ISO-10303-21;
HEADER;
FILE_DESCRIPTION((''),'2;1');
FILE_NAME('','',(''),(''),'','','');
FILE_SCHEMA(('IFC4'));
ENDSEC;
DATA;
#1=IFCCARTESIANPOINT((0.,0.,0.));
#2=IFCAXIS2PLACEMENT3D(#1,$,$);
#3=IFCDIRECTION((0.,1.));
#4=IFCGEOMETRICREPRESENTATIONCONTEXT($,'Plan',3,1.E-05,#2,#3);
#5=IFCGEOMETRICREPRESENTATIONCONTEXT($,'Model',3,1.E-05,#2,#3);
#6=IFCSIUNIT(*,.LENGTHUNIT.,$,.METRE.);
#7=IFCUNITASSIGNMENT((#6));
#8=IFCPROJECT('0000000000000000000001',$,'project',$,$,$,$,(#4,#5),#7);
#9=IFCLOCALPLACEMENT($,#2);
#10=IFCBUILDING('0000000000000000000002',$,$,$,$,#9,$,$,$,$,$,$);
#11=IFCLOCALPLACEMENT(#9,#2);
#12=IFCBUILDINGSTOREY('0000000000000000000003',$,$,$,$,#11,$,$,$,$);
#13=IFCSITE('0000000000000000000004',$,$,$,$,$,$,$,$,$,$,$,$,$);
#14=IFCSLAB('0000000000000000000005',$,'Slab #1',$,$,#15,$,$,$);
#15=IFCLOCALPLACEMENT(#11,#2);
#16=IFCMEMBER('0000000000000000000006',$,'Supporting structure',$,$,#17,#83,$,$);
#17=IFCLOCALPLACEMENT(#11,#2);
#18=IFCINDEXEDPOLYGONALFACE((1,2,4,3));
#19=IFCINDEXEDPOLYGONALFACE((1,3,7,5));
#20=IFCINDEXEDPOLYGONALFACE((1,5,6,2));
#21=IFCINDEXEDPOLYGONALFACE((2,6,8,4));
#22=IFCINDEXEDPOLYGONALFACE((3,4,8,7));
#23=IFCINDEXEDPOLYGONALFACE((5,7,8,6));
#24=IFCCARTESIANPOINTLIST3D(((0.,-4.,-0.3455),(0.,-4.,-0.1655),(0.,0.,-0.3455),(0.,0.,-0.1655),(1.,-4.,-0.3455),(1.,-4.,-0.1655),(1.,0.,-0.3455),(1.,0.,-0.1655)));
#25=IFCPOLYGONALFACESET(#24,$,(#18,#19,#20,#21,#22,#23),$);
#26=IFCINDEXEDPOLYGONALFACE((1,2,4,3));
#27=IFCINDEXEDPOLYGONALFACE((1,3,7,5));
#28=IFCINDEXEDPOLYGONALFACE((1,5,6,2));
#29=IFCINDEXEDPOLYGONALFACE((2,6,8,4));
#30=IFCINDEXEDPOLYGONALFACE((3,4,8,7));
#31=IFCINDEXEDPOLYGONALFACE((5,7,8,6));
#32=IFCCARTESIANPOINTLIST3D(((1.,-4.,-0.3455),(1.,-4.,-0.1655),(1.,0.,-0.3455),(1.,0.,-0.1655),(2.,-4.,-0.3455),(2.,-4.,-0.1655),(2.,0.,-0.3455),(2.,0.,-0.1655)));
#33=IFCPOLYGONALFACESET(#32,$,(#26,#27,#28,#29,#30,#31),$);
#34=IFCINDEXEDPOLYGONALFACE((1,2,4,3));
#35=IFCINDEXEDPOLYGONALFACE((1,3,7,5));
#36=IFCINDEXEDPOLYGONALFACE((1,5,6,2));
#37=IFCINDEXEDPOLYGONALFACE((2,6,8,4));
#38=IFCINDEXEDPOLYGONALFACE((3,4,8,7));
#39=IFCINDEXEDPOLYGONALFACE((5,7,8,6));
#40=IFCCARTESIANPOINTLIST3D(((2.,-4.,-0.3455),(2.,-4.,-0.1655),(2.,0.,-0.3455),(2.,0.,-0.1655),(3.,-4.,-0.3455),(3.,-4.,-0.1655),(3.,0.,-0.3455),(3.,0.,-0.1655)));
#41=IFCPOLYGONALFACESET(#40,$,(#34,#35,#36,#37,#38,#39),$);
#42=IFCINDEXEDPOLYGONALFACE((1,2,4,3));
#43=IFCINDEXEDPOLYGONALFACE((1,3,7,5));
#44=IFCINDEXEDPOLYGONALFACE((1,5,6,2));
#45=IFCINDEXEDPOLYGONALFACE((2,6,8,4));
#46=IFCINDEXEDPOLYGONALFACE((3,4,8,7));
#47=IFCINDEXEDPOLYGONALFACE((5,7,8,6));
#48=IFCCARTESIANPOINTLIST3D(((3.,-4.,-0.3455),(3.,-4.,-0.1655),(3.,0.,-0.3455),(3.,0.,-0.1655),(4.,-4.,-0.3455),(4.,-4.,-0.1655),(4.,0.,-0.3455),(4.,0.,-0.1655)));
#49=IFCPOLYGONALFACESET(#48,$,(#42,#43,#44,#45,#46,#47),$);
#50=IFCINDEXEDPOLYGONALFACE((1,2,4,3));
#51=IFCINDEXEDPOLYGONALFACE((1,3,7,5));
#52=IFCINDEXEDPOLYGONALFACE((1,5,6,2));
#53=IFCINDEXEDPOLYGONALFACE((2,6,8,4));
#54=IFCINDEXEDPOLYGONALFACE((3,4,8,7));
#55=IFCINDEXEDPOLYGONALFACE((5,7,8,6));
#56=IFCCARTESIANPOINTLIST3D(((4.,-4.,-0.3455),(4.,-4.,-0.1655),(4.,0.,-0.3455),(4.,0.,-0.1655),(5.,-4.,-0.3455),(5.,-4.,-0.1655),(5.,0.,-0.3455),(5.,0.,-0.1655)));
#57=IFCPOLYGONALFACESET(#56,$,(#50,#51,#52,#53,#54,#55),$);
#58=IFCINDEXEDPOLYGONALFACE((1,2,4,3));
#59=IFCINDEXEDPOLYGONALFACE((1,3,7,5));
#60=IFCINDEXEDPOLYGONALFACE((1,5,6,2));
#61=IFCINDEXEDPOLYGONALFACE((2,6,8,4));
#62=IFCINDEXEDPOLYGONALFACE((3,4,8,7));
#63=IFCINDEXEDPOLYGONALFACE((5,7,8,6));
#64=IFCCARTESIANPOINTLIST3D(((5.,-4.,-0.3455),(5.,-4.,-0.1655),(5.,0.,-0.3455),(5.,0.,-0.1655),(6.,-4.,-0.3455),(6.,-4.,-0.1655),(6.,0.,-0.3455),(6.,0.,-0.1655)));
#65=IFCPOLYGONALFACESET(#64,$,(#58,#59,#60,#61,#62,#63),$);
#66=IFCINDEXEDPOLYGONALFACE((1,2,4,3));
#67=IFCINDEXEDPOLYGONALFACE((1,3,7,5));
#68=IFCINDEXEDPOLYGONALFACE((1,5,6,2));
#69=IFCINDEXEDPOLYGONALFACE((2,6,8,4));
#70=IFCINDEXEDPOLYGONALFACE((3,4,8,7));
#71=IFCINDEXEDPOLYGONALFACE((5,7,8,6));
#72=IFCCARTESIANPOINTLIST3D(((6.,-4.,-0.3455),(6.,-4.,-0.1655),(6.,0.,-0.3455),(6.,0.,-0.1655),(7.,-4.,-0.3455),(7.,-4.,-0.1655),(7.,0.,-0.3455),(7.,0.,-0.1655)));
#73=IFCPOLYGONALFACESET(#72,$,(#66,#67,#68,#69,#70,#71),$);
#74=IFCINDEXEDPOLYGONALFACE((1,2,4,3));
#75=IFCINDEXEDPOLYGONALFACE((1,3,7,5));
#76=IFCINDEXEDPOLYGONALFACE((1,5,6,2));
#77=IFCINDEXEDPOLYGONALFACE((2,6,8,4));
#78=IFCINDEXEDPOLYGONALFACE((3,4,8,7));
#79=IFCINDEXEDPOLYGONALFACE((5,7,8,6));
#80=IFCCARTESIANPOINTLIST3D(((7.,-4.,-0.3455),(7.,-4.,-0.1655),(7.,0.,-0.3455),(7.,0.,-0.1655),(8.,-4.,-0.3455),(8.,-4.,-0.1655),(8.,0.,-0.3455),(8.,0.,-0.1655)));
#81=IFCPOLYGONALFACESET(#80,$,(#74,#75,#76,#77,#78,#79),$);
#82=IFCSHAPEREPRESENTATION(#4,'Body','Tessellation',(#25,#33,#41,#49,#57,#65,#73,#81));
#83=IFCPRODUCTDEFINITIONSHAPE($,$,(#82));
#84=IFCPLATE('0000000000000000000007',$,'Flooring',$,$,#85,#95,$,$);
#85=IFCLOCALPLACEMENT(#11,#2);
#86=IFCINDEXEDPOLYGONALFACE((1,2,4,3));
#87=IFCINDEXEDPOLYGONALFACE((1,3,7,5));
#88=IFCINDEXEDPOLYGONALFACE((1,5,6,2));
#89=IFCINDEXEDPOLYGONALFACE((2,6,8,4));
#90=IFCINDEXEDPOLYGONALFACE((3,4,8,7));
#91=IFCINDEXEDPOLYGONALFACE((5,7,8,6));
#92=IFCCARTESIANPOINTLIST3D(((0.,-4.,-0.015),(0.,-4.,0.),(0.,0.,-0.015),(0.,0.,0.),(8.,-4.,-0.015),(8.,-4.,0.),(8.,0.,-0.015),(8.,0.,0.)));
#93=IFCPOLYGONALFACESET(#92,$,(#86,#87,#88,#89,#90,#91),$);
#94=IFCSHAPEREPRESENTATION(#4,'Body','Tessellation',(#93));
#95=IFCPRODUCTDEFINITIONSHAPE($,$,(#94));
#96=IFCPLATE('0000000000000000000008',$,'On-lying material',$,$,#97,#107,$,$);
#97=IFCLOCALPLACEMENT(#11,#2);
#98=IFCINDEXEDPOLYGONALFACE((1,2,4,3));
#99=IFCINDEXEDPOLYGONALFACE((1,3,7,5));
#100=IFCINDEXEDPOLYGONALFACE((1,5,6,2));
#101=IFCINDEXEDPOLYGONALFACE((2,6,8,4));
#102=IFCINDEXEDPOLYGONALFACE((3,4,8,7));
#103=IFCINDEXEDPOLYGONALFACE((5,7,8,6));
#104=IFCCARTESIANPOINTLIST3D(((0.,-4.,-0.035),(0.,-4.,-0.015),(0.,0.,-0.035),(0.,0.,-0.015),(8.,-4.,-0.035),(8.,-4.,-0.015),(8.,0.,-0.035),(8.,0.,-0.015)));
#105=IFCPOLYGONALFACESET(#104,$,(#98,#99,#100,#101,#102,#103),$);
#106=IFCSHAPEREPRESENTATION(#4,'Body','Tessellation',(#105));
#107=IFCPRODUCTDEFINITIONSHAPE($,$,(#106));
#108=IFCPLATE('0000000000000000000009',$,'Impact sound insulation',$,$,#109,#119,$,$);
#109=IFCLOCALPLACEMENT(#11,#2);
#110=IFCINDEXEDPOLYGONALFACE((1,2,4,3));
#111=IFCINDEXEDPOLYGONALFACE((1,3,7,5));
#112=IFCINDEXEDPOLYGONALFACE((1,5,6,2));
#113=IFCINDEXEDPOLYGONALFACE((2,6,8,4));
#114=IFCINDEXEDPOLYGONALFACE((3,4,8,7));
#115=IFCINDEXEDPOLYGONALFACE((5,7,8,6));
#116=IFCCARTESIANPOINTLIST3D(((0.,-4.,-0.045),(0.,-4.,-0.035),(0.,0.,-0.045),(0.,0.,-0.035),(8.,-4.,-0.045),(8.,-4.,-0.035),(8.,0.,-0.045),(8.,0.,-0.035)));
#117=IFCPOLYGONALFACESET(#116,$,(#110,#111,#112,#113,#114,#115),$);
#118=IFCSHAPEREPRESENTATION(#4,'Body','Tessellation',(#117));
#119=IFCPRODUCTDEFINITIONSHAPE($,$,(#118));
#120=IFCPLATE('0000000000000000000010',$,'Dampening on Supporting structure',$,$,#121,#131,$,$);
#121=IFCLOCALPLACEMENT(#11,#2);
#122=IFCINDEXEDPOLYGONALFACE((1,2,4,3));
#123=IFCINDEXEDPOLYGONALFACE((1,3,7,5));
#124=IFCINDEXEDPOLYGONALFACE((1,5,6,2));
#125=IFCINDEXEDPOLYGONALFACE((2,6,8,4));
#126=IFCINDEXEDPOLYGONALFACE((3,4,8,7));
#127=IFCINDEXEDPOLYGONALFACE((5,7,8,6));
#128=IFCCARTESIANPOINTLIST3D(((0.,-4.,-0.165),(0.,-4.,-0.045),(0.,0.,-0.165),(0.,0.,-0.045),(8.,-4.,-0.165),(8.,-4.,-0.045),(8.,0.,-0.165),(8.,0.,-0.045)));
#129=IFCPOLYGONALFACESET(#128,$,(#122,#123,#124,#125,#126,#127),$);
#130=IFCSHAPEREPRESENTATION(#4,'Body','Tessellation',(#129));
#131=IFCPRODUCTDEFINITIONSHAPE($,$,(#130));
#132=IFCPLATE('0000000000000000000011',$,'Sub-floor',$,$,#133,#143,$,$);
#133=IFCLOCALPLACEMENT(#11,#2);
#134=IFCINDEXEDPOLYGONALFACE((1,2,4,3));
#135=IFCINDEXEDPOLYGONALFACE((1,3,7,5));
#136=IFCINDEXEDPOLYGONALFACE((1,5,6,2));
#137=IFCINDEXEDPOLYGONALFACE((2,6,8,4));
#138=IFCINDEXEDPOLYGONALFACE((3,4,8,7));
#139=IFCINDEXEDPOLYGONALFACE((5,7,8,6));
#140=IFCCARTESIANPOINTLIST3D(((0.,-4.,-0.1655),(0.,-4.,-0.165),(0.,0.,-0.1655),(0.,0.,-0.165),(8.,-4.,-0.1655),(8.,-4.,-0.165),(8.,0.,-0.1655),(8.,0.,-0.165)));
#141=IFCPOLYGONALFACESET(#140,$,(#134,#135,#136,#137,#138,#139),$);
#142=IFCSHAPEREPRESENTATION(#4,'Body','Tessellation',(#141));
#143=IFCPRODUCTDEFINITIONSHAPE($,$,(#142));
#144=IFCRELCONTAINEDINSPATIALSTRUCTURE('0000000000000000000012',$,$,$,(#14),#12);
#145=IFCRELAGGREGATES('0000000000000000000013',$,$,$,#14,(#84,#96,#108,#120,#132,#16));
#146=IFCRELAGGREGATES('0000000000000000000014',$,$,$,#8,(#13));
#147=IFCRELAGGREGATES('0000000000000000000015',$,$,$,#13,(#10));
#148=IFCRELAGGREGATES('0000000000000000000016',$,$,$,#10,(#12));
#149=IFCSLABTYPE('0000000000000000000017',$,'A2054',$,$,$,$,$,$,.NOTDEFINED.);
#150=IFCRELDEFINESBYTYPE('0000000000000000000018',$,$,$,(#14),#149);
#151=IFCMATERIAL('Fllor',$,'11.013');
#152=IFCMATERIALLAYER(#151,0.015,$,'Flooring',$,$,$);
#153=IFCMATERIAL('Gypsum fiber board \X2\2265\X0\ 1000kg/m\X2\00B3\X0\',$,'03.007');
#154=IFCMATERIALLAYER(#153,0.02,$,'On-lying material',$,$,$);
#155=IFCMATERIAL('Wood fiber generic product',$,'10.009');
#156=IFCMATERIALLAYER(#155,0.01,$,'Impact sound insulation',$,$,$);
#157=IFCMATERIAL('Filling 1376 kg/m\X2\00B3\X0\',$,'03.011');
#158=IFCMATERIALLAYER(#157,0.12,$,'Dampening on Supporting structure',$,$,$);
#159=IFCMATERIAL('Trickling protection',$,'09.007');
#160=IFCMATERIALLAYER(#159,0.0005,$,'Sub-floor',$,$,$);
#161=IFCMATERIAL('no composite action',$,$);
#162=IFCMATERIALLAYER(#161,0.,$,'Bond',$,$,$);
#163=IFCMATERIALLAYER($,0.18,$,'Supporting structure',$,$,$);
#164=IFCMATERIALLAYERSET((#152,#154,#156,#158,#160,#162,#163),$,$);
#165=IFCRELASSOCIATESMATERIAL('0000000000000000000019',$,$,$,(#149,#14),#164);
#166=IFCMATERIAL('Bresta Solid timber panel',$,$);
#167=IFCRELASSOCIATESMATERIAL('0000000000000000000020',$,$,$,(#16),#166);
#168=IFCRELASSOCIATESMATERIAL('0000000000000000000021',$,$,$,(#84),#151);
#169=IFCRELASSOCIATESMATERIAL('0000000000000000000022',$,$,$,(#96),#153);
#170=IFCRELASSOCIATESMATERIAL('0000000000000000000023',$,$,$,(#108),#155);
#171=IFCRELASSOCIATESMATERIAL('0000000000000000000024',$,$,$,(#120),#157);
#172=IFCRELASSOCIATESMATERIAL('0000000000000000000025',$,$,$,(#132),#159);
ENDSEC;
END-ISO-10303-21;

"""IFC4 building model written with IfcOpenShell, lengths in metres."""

from ifc_helpers import new_model, si_unit, direction, frame, frame_2d, origin, origin_with_axes, place, context, project, spatial, rectangle, extrude, material, layer, layer_set, type_object, element, aggregate, save


model = new_model("IFC4")

# Units and contexts
plan_context = context("Plan", 3, precision=1e-05, world=origin(), true_north=direction((0.0, 1.0)))
model_context = context("Model", 3, precision=1e-05, world=origin(), true_north=direction((0.0, 1.0)))
ifc_project = project(units=[si_unit("LENGTHUNIT", "METRE")], contexts=[plan_context, model_context])

# Site, building, storey
site = spatial("IfcSite", under=ifc_project)
building_placement = place(None, origin())
building = spatial("IfcBuilding", under=site, at=building_placement)
storey_placement = place(building_placement, origin())
storey = spatial("IfcBuildingStorey", under=building, at=storey_placement)

# Slab, member, plates
ifc_material_1 = material(Name="Fllor", Category="11.013")
ifc_layer_1 = layer(ifc_material_1, 0.015, Name="Flooring")
ifc_material_2 = material(Name="Gypsum fiber board ≥ 1000kg/m³", Category="03.007")
ifc_layer_2 = layer(ifc_material_2, 0.02, Name="On-lying material")
ifc_material_3 = material(Name="Wood fiber generic product", Category="10.009")
ifc_layer_3 = layer(ifc_material_3, 0.01, Name="Impact sound insulation")
ifc_material_4 = material(Name="Filling 1376 kg/m³", Category="03.011")
ifc_layer_4 = layer(ifc_material_4, 0.12, Name="Dampening on Supporting structure")
ifc_material_5 = material(Name="Trickling protection", Category="09.007")
ifc_layer_5 = layer(ifc_material_5, 0.0005, Name="Sub-floor")
ifc_material_6 = material(Name="no composite action")
ifc_layer_6 = layer(ifc_material_6, 0.0, Name="Bond")
ifc_layer_7 = layer(None, 0.18, Name="Supporting structure")
ifc_layer_set = layer_set([ifc_layer_1, ifc_layer_2, ifc_layer_3, ifc_layer_4, ifc_layer_5, ifc_layer_6, ifc_layer_7])
slab_type = type_object("IfcSlabType", Name="A2054", PredefinedType="NOTDEFINED", material=ifc_layer_set)
slab_placement = place(None, frame((0.0, 0.0, 0.0), z_axis=(0.0, 0.0, -1.0), x_axis=(1.0, 0.0, 0.0)))
slab = element("IfcSlab", 1, at=slab_placement, inside=storey, type_object=slab_type, material=ifc_layer_set, Name="Slab #1")
ifc_material_7 = material(Name="Bresta Solid timber panel")
member_placement = place(slab_placement, origin())
member = element("IfcMember", 2, at=member_placement, material=ifc_material_7, Name="Supporting structure", context=plan_context, shape_type="SweptSolid", body=[
    extrude(rectangle(XDim=1.0, YDim=0.18, at=frame_2d((0.5, 0.09), x_axis=(1.0, 0.0))), frame((0.0, 4.0, 0.1655), z_axis=(0.0, -1.0, 0.0), x_axis=(1.0, 0.0, 0.0)), (0.0, 0.0, 1.0), 4.0),
    extrude(rectangle(XDim=1.0, YDim=0.18, at=frame_2d((0.5, 0.09), x_axis=(1.0, 0.0))), frame((1.0, 4.0, 0.1655), z_axis=(0.0, -1.0, 0.0), x_axis=(1.0, 0.0, 0.0)), (0.0, 0.0, 1.0), 4.0),
    extrude(rectangle(XDim=1.0, YDim=0.18, at=frame_2d((0.5, 0.09), x_axis=(1.0, 0.0))), frame((2.0, 4.0, 0.1655), z_axis=(0.0, -1.0, 0.0), x_axis=(1.0, 0.0, 0.0)), (0.0, 0.0, 1.0), 4.0),
    extrude(rectangle(XDim=1.0, YDim=0.18, at=frame_2d((0.5, 0.09), x_axis=(1.0, 0.0))), frame((3.0, 4.0, 0.1655), z_axis=(0.0, -1.0, 0.0), x_axis=(1.0, 0.0, 0.0)), (0.0, 0.0, 1.0), 4.0),
    extrude(rectangle(XDim=1.0, YDim=0.18, at=frame_2d((0.5, 0.09), x_axis=(1.0, 0.0))), frame((4.0, 4.0, 0.1655), z_axis=(0.0, -1.0, 0.0), x_axis=(1.0, 0.0, 0.0)), (0.0, 0.0, 1.0), 4.0),
    extrude(rectangle(XDim=1.0, YDim=0.18, at=frame_2d((0.5, 0.09), x_axis=(1.0, 0.0))), frame((5.0, 4.0, 0.1655), z_axis=(0.0, -1.0, 0.0), x_axis=(1.0, 0.0, 0.0)), (0.0, 0.0, 1.0), 4.0),
    extrude(rectangle(XDim=1.0, YDim=0.18, at=frame_2d((0.5, 0.09), x_axis=(1.0, 0.0))), frame((6.0, 4.0, 0.1655), z_axis=(0.0, -1.0, 0.0), x_axis=(1.0, 0.0, 0.0)), (0.0, 0.0, 1.0), 4.0),
    extrude(rectangle(XDim=1.0, YDim=0.18, at=frame_2d((0.5, 0.09), x_axis=(1.0, 0.0))), frame((7.0, 4.0, 0.1655), z_axis=(0.0, -1.0, 0.0), x_axis=(1.0, 0.0, 0.0)), (0.0, 0.0, 1.0), 4.0),
])
plate_1_placement = place(slab_placement, origin())
plate_1 = element("IfcPlate", 3, at=plate_1_placement, material=ifc_material_1, Name="Flooring", context=plan_context, shape_type="SweptSolid", body=[
    extrude(rectangle(XDim=8.0, YDim=4.0, at=frame_2d((4.0, 2.0), x_axis=(1.0, 0.0))), origin_with_axes(), (0.0, 0.0, 1.0), 0.015),
])
plate_2_placement = place(slab_placement, origin())
plate_2 = element("IfcPlate", 4, at=plate_2_placement, material=ifc_material_2, Name="On-lying material", context=plan_context, shape_type="SweptSolid", body=[
    extrude(rectangle(XDim=8.0, YDim=4.0, at=frame_2d((4.0, 2.0), x_axis=(1.0, 0.0))), frame((0.0, 0.0, 0.015), z_axis=(0.0, 0.0, 1.0), x_axis=(1.0, 0.0, 0.0)), (0.0, 0.0, 1.0), 0.02),
])
plate_3_placement = place(slab_placement, origin())
plate_3 = element("IfcPlate", 5, at=plate_3_placement, material=ifc_material_3, Name="Impact sound insulation", context=plan_context, shape_type="SweptSolid", body=[
    extrude(rectangle(XDim=8.0, YDim=4.0, at=frame_2d((4.0, 2.0), x_axis=(1.0, 0.0))), frame((0.0, 0.0, 0.035), z_axis=(0.0, 0.0, 1.0), x_axis=(1.0, 0.0, 0.0)), (0.0, 0.0, 1.0), 0.01),
])
plate_4_placement = place(slab_placement, origin())
plate_4 = element("IfcPlate", 6, at=plate_4_placement, material=ifc_material_4, Name="Dampening on Supporting structure", context=plan_context, shape_type="SweptSolid", body=[
    extrude(rectangle(XDim=8.0, YDim=4.0, at=frame_2d((4.0, 2.0), x_axis=(1.0, 0.0))), frame((0.0, 0.0, 0.045), z_axis=(0.0, 0.0, 1.0), x_axis=(1.0, 0.0, 0.0)), (0.0, 0.0, 1.0), 0.12),
])
plate_5_placement = place(slab_placement, origin())
plate_5 = element("IfcPlate", 7, at=plate_5_placement, material=ifc_material_5, Name="Sub-floor", context=plan_context, shape_type="SweptSolid", body=[
    extrude(rectangle(XDim=8.0, YDim=4.0, at=frame_2d((4.0, 2.0), x_axis=(1.0, 0.0))), frame((0.0, 0.0, 0.165), z_axis=(0.0, 0.0, 1.0), x_axis=(1.0, 0.0, 0.0)), (0.0, 0.0, 1.0), 0.0005),
])
aggregate(slab, [plate_1, plate_2, plate_3, plate_4, plate_5, member])

save(model, "model.ifc")
